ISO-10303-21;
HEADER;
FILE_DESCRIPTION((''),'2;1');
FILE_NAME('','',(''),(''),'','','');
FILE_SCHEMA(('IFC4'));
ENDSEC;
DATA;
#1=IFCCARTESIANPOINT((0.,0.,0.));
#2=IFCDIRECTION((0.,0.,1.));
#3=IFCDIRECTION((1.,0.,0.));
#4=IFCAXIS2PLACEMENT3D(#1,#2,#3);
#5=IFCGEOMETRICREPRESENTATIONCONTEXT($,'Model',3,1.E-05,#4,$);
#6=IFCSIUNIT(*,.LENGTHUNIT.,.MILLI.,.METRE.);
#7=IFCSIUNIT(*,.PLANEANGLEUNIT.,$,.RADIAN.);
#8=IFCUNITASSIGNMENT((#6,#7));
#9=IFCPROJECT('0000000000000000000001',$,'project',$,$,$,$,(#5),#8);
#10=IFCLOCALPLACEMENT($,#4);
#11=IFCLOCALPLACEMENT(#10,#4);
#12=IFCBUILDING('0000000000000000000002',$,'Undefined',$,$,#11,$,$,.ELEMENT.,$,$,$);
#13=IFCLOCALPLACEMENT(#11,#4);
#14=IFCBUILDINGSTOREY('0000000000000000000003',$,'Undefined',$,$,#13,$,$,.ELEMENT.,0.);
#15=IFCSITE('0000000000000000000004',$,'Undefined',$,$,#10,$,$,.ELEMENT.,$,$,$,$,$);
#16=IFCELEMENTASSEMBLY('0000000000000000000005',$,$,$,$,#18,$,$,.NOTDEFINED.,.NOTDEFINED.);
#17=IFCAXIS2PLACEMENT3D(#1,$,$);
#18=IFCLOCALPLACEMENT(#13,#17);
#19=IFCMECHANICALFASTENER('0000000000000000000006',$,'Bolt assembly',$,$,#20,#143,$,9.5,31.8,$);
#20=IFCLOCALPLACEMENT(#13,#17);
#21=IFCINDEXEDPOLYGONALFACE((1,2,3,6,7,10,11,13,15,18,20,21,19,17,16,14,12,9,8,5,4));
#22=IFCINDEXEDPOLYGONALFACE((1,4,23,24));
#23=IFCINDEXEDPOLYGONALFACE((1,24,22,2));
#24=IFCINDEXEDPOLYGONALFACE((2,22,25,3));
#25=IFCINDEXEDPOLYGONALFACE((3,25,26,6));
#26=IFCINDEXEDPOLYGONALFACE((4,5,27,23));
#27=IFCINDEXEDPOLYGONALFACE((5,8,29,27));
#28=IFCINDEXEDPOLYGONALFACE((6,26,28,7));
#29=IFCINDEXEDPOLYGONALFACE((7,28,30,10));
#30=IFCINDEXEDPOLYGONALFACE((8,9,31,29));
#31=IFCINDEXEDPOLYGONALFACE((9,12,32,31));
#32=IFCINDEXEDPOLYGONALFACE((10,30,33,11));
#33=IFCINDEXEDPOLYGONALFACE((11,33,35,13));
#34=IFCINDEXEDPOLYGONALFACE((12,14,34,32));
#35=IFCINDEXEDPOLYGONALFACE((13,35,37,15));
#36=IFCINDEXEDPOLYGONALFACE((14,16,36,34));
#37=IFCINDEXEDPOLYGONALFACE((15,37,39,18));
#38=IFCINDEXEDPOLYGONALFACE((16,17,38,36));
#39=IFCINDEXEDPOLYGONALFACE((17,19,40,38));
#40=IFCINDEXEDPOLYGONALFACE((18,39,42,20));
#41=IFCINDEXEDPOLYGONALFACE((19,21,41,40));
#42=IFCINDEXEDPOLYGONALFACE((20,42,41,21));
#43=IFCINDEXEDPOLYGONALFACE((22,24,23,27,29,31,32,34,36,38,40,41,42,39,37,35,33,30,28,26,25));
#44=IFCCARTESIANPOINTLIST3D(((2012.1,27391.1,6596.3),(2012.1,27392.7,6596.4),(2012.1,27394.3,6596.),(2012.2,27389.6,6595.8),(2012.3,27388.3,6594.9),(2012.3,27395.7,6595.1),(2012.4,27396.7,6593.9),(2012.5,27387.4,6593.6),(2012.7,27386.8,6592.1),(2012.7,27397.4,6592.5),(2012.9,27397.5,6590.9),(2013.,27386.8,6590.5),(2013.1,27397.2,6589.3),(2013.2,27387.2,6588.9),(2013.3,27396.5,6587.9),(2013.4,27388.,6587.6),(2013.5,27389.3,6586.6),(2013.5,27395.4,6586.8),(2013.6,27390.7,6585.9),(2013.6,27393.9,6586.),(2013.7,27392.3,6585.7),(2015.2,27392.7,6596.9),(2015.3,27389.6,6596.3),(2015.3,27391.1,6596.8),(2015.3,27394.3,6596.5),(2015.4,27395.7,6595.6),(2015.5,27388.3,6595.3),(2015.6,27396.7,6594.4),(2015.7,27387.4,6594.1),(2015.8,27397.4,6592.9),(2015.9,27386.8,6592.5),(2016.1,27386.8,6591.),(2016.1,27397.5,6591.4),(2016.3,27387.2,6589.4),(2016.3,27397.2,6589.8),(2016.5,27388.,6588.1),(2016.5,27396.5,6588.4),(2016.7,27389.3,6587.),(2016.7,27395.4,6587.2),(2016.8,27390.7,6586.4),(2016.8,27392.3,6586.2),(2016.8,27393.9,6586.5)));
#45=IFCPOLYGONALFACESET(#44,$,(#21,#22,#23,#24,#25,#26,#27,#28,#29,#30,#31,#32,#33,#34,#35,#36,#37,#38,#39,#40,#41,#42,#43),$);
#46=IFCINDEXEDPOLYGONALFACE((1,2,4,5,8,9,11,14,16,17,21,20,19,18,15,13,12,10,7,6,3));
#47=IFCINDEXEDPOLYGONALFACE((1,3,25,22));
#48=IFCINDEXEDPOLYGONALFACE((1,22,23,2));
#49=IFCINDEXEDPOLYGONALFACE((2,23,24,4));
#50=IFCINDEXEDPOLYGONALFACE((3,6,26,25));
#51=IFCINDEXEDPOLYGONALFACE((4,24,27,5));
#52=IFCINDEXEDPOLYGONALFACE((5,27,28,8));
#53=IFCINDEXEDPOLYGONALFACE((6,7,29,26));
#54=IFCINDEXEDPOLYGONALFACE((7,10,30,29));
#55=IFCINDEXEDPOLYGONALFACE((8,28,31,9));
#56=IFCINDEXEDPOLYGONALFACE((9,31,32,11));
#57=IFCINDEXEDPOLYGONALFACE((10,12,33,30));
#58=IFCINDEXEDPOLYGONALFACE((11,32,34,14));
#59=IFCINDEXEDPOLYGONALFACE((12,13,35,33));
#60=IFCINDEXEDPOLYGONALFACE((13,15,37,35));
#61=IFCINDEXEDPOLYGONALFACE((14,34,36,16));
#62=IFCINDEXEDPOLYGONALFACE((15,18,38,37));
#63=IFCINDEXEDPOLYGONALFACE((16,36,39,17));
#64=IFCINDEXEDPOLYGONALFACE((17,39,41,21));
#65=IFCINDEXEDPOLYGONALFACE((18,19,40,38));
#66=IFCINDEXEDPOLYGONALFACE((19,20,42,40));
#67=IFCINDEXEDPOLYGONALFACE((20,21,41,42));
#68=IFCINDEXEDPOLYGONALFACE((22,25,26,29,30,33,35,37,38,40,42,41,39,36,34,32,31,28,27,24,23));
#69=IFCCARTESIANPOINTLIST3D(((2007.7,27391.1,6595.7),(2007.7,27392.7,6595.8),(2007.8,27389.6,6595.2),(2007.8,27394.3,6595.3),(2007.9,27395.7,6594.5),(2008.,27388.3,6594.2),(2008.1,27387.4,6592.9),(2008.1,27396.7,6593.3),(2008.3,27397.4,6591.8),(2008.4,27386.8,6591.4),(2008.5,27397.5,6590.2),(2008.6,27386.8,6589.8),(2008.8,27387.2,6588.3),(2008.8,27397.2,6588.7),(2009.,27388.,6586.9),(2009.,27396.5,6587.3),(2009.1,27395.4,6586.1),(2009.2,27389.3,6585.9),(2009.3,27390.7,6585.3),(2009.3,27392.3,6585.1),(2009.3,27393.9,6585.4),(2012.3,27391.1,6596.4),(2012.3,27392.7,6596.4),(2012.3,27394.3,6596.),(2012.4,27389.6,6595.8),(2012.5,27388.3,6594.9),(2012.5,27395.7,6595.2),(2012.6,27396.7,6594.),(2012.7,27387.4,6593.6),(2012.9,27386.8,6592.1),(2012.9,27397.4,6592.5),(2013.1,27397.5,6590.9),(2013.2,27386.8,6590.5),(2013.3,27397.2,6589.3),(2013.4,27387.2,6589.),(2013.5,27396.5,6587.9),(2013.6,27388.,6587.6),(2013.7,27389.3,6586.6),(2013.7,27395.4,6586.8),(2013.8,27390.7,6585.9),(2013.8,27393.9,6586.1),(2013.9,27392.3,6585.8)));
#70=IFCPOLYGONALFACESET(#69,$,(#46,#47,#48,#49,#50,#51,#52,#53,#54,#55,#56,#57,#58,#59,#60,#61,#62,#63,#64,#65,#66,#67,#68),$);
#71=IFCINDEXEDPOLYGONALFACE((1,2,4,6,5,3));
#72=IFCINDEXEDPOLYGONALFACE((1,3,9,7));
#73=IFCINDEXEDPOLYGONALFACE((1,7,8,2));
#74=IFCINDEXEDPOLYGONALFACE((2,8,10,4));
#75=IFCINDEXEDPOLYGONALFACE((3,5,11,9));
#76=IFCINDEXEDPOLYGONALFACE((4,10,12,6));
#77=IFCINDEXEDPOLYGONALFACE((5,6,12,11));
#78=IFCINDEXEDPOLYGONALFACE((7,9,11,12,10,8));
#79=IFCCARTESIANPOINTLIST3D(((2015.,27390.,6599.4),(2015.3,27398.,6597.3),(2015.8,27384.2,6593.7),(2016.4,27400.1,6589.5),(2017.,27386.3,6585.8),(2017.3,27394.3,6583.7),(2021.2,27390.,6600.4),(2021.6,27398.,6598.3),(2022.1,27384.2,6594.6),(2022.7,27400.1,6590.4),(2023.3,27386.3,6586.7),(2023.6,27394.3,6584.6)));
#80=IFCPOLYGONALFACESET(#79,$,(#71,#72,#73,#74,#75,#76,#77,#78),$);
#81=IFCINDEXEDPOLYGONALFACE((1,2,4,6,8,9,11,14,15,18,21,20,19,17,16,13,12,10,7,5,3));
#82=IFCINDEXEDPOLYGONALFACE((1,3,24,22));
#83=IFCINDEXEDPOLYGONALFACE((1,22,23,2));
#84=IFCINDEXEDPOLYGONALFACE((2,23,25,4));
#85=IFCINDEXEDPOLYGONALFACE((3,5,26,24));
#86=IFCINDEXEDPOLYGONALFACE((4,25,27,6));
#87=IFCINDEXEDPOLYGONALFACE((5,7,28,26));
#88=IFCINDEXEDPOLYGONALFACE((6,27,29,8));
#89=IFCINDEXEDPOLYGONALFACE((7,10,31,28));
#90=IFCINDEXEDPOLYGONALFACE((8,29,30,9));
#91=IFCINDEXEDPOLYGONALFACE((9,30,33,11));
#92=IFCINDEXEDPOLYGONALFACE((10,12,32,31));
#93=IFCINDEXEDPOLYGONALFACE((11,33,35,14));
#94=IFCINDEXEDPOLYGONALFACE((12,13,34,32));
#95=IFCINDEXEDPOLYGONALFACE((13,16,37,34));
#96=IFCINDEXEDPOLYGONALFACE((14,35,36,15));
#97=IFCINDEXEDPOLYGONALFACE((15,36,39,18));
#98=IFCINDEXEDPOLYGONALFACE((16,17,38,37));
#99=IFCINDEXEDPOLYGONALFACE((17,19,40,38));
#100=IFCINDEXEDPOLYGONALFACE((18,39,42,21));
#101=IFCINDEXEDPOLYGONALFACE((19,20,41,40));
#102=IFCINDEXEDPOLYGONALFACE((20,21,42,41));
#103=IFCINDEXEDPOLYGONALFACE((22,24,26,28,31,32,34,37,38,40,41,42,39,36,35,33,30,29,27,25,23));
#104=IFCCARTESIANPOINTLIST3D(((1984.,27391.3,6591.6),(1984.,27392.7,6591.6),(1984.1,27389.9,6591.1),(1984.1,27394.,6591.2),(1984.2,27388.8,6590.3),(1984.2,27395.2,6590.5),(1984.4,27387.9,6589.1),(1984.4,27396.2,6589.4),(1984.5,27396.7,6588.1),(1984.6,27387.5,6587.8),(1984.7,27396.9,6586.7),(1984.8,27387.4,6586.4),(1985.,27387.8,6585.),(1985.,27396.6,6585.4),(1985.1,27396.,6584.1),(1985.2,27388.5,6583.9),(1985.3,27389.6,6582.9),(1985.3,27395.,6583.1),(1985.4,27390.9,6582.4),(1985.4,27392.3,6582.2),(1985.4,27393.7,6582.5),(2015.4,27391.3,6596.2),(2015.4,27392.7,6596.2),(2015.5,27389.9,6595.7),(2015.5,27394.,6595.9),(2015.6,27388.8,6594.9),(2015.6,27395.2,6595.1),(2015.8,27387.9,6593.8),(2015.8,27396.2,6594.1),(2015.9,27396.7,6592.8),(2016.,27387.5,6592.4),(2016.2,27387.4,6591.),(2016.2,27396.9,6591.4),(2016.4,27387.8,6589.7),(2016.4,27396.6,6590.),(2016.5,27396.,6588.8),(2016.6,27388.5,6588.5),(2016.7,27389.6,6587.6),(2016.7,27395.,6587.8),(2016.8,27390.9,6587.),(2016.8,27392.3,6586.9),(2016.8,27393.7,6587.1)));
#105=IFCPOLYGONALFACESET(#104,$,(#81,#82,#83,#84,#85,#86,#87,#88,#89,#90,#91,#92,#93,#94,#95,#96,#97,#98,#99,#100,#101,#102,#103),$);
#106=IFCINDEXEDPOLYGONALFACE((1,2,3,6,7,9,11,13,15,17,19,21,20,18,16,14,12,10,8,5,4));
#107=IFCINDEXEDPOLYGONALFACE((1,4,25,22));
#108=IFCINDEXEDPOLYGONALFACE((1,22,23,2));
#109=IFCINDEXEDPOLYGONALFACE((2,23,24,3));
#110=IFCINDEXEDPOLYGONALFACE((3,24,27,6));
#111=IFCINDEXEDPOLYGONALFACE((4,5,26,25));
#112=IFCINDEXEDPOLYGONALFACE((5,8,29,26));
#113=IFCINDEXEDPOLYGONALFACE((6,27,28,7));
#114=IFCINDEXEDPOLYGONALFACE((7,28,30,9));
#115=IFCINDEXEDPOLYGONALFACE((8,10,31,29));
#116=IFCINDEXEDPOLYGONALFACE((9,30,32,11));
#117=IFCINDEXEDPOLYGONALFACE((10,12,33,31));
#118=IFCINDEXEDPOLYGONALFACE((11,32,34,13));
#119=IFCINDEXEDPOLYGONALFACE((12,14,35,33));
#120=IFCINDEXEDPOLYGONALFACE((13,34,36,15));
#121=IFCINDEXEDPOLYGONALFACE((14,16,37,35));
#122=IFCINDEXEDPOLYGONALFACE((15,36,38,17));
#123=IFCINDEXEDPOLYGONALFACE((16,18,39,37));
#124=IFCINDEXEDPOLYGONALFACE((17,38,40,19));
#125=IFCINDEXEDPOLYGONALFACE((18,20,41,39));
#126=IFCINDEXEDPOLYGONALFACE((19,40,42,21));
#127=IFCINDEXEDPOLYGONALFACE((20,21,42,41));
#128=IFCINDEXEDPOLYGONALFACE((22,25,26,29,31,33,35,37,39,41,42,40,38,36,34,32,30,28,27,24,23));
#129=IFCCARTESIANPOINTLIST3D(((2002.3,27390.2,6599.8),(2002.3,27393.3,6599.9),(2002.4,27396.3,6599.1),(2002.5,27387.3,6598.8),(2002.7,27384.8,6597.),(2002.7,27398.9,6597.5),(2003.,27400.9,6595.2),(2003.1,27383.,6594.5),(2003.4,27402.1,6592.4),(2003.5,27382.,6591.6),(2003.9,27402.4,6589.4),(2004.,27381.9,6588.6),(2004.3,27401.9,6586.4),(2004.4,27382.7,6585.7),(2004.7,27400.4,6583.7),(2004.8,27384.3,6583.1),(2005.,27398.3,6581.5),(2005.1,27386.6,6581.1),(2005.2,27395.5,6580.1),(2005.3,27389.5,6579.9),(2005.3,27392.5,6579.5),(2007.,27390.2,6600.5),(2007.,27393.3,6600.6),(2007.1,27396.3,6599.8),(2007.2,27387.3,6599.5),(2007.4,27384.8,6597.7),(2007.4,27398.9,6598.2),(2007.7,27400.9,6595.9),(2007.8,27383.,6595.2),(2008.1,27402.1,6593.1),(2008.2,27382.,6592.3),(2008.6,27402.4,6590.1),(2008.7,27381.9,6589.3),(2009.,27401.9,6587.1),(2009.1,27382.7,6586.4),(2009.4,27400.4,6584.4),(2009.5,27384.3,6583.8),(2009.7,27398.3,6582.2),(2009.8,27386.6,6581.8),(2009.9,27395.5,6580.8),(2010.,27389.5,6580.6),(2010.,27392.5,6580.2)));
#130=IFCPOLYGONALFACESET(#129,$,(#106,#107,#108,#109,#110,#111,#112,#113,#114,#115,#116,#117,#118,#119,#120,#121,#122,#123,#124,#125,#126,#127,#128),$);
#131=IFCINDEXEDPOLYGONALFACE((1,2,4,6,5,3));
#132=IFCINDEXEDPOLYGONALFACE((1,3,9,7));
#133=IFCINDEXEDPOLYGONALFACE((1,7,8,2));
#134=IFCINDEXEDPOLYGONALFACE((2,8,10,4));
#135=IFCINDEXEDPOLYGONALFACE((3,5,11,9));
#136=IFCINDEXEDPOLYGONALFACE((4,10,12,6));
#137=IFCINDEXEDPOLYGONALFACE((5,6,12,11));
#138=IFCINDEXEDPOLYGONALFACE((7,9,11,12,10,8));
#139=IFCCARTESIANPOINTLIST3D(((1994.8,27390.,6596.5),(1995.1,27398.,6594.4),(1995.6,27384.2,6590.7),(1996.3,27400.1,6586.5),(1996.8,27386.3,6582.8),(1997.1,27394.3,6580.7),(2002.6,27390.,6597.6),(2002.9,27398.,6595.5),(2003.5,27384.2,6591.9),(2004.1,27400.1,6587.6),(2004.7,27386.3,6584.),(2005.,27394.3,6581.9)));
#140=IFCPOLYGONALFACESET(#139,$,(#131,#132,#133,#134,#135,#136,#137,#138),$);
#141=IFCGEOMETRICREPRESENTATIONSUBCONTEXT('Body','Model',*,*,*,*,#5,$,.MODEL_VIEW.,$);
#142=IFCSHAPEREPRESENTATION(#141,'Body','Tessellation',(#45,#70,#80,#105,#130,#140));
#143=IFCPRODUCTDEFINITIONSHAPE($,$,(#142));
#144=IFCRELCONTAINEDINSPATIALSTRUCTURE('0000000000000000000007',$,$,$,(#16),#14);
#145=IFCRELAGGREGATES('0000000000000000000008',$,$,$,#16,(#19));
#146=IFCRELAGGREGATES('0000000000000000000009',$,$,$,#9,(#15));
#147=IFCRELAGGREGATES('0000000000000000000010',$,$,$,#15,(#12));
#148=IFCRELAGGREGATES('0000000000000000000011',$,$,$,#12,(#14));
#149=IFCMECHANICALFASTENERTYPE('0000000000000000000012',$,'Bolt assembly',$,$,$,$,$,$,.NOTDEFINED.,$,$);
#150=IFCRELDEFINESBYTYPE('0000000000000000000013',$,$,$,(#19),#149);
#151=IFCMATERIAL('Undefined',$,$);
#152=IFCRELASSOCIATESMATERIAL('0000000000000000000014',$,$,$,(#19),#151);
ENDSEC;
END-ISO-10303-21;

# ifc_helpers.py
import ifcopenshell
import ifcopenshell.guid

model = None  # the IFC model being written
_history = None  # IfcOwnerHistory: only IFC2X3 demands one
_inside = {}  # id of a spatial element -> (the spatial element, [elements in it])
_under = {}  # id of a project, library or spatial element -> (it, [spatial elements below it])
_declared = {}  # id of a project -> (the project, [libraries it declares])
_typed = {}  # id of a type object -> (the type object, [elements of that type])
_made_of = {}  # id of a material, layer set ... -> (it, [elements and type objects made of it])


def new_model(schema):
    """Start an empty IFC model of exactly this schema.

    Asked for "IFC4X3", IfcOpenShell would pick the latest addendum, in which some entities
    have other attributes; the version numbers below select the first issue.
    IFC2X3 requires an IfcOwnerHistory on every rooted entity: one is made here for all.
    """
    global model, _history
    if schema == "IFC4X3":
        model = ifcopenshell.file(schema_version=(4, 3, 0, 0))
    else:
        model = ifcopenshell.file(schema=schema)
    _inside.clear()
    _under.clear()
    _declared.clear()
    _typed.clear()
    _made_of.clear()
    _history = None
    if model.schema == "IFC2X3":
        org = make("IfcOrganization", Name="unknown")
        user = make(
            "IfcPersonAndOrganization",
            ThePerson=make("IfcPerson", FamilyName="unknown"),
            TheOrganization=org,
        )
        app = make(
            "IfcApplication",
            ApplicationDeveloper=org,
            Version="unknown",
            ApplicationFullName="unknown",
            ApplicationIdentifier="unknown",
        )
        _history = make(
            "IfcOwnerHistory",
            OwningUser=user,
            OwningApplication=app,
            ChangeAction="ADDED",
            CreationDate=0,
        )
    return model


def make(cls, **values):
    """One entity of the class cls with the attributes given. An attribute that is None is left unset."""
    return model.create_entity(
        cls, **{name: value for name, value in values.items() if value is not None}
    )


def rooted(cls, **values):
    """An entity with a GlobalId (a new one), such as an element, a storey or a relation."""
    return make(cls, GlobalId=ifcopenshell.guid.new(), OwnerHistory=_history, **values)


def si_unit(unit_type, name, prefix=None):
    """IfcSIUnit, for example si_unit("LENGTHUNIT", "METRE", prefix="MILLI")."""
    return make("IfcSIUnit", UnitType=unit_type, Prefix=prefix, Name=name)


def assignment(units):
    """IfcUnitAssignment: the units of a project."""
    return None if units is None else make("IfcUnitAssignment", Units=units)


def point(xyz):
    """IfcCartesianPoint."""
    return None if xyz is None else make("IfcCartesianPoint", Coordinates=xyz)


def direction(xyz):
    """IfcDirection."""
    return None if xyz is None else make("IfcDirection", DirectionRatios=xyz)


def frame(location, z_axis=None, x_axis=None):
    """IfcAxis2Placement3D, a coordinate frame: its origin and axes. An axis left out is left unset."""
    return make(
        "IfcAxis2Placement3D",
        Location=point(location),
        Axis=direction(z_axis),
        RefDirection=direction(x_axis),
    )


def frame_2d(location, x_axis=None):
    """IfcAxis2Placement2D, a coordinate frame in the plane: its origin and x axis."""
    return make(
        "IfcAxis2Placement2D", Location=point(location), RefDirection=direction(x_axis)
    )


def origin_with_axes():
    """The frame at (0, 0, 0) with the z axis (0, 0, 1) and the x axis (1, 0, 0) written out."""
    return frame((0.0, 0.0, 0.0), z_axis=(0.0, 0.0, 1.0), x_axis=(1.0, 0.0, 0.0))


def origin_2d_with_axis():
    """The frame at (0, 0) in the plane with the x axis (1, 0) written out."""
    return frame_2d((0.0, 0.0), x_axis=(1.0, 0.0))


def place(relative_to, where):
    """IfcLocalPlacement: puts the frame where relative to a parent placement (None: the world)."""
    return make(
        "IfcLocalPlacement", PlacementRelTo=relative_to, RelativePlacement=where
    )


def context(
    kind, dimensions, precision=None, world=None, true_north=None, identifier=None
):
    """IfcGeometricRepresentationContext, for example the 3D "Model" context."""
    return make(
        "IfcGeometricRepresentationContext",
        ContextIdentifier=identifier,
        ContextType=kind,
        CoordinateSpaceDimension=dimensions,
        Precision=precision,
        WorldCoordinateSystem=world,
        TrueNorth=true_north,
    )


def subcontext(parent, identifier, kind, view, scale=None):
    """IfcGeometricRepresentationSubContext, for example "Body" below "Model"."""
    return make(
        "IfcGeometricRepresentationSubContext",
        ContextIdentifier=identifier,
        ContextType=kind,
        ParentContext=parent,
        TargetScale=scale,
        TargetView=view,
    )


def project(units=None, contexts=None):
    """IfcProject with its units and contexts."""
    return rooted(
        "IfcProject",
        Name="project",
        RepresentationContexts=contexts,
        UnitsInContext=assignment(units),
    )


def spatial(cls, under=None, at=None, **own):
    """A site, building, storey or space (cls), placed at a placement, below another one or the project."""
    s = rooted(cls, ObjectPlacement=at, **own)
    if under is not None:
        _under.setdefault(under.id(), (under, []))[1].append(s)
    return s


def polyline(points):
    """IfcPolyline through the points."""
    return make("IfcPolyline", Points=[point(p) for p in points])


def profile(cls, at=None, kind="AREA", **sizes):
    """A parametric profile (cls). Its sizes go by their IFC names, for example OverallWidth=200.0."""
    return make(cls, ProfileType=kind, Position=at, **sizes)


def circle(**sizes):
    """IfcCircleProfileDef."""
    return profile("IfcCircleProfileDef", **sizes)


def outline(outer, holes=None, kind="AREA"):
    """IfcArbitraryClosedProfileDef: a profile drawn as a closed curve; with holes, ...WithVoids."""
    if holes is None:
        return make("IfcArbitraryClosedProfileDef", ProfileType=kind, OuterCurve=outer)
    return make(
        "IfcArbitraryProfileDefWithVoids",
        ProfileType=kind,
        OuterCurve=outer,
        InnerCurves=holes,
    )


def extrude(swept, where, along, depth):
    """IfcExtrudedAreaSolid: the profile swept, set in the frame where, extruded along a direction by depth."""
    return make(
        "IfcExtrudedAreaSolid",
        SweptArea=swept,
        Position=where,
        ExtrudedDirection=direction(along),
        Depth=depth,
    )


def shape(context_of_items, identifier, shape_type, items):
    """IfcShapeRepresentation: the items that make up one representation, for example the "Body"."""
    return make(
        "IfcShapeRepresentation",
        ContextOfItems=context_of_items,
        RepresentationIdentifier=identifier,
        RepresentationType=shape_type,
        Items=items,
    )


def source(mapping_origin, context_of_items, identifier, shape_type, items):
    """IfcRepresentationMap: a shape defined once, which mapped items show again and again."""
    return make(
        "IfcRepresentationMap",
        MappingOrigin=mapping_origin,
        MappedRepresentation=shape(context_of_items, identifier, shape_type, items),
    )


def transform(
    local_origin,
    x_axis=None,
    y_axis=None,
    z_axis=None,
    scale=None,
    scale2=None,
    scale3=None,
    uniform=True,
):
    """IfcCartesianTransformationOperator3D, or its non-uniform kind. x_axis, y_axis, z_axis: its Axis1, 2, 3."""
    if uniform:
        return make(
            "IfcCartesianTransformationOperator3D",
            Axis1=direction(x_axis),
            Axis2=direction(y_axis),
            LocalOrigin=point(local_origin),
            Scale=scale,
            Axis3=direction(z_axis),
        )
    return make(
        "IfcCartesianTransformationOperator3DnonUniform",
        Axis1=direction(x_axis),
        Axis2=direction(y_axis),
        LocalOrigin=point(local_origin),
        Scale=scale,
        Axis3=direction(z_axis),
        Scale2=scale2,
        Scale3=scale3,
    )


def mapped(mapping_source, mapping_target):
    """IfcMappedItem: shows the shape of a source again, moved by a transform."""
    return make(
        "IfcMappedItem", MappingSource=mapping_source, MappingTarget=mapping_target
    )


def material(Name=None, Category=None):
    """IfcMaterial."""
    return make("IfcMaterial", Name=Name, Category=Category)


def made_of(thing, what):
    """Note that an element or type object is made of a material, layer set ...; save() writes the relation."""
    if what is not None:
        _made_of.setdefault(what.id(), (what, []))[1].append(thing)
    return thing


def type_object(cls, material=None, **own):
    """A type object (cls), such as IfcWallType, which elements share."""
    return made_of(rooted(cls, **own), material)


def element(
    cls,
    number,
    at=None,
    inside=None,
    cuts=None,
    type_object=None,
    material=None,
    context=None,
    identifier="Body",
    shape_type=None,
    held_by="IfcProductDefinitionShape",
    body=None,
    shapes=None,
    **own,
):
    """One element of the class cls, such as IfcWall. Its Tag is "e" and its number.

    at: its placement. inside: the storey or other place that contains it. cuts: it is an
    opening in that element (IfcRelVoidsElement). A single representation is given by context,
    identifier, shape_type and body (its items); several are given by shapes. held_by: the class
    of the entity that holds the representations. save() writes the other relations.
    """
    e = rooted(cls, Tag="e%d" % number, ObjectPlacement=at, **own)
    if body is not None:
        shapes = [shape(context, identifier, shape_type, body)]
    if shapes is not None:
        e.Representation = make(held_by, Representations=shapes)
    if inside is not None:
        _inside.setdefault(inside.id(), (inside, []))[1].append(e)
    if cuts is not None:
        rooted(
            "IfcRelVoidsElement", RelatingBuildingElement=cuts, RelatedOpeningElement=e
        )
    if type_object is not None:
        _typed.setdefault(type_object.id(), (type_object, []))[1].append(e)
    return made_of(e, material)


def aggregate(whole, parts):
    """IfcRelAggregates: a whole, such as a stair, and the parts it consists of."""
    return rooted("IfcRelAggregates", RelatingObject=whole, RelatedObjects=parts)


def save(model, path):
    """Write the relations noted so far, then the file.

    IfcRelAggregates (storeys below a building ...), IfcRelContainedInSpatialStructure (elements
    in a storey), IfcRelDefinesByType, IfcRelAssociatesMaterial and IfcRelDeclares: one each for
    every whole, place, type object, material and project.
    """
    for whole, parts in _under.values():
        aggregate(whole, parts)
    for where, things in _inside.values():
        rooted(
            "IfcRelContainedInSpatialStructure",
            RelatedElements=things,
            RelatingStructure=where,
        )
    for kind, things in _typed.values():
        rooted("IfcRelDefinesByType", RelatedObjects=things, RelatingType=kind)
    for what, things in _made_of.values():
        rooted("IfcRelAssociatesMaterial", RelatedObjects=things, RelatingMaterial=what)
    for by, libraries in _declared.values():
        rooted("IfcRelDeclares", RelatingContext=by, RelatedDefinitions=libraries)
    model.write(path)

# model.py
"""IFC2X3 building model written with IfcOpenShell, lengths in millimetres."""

from ifc_helpers import new_model, si_unit, frame, origin_with_axes, origin_2d_with_axis, place, context, subcontext, project, spatial, polyline, circle, outline, extrude, source, transform, mapped, material, type_object, element, aggregate, save


model = new_model("IFC2X3")

# Units and contexts
model_context = context("Model", 3, precision=1e-05, world=origin_with_axes())
body_context = subcontext(model_context, "Body", "Model", "MODEL_VIEW")
ifc_project = project(units=[si_unit("LENGTHUNIT", "METRE", prefix="MILLI"), si_unit("PLANEANGLEUNIT", "RADIAN")], contexts=[model_context])

# Site, building, storey
site_placement = place(None, origin_with_axes())
site = spatial("IfcSite", under=ifc_project, at=site_placement, Name="Undefined", CompositionType="ELEMENT")
building_placement = place(site_placement, origin_with_axes())
building = spatial("IfcBuilding", under=site, at=building_placement, Name="Undefined", CompositionType="ELEMENT")
storey_placement = place(building_placement, origin_with_axes())
storey = spatial("IfcBuildingStorey", under=building, at=storey_placement, Name="Undefined", CompositionType="ELEMENT", Elevation=0.0)

# Element assembly
assembly_1_placement = place(storey_placement, origin_with_axes())
assembly_1 = element("IfcElementAssembly", 1, at=assembly_1_placement, inside=storey, AssemblyPlace="NOTDEFINED", PredefinedType="NOTDEFINED")

# Shared definitions
ifc_material_1 = material(Name="Undefined")
mechanical_fastener_type = type_object("IfcMechanicalFastenerType", Name="Bolt assembly")

# Mechanical fastener
shared_shape_1 = source(origin_with_axes(), body_context, "Body", "SweptSolid", [
    extrude(circle(Radius=5.4, at=origin_2d_with_axis()), frame((0.0, -3.1, 0.0), z_axis=(0.0, 1.0, 0.0), x_axis=(1.0, 0.0, 0.0)), (0.0, 0.0, 1.0), 3.2),
    extrude(circle(Radius=5.4, at=origin_2d_with_axis()), frame((0.0, -0.1, 0.0), z_axis=(0.0, 1.0, 0.0), x_axis=(1.0, 0.0, 0.0)), (0.0, 0.0, 1.0), 4.6),
    extrude(outline(polyline([(7.1, -4.1), (7.1, 4.1), (0.0, 8.2), (-7.1, 4.1), (-7.1, -4.1), (0.0, -8.2), (7.1, -4.1)])), frame((0.0, -9.6, 0.0), z_axis=(0.0, 1.0, 0.0), x_axis=(1.0, 0.0, 0.0)), (0.0, 0.0, 1.0), 6.3),
    extrude(circle(Radius=4.8, at=origin_2d_with_axis()), frame((0.0, -3.2, 0.0), z_axis=(0.0, 1.0, 0.0), x_axis=(1.0, 0.0, 0.0)), (0.0, 0.0, 1.0), 31.8),
    extrude(circle(Radius=10.3, at=origin_2d_with_axis()), frame((0.0, 4.5, 0.0), z_axis=(0.0, 1.0, 0.0), x_axis=(1.0, 0.0, 0.0)), (0.0, 0.0, 1.0), 4.8),
    extrude(outline(polyline([(7.1, -4.1), (7.1, 4.1), (0.0, 8.2), (-7.1, 4.1), (-7.1, -4.1), (0.0, -8.2), (7.1, -4.1)])), frame((0.0, 9.3, 0.0), z_axis=(0.0, 1.0, 0.0), x_axis=(1.0, 0.0, 0.0)), (0.0, 0.0, 1.0), 7.9),
])
mechanical_fastener_1_placement = place(assembly_1_placement, frame((2013.0, 27392.1, 6591.1), z_axis=(0.103381, -0.707107, -0.699509), x_axis=(-0.103381, -0.707107, 0.699509)))
mechanical_fastener_1 = element("IfcMechanicalFastener", 2, at=mechanical_fastener_1_placement, type_object=mechanical_fastener_type, material=ifc_material_1, Name="Bolt assembly", NominalDiameter=9.5, NominalLength=31.8, context=body_context, shape_type="MappedRepresentation", body=[
    mapped(shared_shape_1, transform((0.0, 0.0, 0.0))),
])
aggregate(assembly_1, [mechanical_fastener_1])

save(model, "model.ifc")
